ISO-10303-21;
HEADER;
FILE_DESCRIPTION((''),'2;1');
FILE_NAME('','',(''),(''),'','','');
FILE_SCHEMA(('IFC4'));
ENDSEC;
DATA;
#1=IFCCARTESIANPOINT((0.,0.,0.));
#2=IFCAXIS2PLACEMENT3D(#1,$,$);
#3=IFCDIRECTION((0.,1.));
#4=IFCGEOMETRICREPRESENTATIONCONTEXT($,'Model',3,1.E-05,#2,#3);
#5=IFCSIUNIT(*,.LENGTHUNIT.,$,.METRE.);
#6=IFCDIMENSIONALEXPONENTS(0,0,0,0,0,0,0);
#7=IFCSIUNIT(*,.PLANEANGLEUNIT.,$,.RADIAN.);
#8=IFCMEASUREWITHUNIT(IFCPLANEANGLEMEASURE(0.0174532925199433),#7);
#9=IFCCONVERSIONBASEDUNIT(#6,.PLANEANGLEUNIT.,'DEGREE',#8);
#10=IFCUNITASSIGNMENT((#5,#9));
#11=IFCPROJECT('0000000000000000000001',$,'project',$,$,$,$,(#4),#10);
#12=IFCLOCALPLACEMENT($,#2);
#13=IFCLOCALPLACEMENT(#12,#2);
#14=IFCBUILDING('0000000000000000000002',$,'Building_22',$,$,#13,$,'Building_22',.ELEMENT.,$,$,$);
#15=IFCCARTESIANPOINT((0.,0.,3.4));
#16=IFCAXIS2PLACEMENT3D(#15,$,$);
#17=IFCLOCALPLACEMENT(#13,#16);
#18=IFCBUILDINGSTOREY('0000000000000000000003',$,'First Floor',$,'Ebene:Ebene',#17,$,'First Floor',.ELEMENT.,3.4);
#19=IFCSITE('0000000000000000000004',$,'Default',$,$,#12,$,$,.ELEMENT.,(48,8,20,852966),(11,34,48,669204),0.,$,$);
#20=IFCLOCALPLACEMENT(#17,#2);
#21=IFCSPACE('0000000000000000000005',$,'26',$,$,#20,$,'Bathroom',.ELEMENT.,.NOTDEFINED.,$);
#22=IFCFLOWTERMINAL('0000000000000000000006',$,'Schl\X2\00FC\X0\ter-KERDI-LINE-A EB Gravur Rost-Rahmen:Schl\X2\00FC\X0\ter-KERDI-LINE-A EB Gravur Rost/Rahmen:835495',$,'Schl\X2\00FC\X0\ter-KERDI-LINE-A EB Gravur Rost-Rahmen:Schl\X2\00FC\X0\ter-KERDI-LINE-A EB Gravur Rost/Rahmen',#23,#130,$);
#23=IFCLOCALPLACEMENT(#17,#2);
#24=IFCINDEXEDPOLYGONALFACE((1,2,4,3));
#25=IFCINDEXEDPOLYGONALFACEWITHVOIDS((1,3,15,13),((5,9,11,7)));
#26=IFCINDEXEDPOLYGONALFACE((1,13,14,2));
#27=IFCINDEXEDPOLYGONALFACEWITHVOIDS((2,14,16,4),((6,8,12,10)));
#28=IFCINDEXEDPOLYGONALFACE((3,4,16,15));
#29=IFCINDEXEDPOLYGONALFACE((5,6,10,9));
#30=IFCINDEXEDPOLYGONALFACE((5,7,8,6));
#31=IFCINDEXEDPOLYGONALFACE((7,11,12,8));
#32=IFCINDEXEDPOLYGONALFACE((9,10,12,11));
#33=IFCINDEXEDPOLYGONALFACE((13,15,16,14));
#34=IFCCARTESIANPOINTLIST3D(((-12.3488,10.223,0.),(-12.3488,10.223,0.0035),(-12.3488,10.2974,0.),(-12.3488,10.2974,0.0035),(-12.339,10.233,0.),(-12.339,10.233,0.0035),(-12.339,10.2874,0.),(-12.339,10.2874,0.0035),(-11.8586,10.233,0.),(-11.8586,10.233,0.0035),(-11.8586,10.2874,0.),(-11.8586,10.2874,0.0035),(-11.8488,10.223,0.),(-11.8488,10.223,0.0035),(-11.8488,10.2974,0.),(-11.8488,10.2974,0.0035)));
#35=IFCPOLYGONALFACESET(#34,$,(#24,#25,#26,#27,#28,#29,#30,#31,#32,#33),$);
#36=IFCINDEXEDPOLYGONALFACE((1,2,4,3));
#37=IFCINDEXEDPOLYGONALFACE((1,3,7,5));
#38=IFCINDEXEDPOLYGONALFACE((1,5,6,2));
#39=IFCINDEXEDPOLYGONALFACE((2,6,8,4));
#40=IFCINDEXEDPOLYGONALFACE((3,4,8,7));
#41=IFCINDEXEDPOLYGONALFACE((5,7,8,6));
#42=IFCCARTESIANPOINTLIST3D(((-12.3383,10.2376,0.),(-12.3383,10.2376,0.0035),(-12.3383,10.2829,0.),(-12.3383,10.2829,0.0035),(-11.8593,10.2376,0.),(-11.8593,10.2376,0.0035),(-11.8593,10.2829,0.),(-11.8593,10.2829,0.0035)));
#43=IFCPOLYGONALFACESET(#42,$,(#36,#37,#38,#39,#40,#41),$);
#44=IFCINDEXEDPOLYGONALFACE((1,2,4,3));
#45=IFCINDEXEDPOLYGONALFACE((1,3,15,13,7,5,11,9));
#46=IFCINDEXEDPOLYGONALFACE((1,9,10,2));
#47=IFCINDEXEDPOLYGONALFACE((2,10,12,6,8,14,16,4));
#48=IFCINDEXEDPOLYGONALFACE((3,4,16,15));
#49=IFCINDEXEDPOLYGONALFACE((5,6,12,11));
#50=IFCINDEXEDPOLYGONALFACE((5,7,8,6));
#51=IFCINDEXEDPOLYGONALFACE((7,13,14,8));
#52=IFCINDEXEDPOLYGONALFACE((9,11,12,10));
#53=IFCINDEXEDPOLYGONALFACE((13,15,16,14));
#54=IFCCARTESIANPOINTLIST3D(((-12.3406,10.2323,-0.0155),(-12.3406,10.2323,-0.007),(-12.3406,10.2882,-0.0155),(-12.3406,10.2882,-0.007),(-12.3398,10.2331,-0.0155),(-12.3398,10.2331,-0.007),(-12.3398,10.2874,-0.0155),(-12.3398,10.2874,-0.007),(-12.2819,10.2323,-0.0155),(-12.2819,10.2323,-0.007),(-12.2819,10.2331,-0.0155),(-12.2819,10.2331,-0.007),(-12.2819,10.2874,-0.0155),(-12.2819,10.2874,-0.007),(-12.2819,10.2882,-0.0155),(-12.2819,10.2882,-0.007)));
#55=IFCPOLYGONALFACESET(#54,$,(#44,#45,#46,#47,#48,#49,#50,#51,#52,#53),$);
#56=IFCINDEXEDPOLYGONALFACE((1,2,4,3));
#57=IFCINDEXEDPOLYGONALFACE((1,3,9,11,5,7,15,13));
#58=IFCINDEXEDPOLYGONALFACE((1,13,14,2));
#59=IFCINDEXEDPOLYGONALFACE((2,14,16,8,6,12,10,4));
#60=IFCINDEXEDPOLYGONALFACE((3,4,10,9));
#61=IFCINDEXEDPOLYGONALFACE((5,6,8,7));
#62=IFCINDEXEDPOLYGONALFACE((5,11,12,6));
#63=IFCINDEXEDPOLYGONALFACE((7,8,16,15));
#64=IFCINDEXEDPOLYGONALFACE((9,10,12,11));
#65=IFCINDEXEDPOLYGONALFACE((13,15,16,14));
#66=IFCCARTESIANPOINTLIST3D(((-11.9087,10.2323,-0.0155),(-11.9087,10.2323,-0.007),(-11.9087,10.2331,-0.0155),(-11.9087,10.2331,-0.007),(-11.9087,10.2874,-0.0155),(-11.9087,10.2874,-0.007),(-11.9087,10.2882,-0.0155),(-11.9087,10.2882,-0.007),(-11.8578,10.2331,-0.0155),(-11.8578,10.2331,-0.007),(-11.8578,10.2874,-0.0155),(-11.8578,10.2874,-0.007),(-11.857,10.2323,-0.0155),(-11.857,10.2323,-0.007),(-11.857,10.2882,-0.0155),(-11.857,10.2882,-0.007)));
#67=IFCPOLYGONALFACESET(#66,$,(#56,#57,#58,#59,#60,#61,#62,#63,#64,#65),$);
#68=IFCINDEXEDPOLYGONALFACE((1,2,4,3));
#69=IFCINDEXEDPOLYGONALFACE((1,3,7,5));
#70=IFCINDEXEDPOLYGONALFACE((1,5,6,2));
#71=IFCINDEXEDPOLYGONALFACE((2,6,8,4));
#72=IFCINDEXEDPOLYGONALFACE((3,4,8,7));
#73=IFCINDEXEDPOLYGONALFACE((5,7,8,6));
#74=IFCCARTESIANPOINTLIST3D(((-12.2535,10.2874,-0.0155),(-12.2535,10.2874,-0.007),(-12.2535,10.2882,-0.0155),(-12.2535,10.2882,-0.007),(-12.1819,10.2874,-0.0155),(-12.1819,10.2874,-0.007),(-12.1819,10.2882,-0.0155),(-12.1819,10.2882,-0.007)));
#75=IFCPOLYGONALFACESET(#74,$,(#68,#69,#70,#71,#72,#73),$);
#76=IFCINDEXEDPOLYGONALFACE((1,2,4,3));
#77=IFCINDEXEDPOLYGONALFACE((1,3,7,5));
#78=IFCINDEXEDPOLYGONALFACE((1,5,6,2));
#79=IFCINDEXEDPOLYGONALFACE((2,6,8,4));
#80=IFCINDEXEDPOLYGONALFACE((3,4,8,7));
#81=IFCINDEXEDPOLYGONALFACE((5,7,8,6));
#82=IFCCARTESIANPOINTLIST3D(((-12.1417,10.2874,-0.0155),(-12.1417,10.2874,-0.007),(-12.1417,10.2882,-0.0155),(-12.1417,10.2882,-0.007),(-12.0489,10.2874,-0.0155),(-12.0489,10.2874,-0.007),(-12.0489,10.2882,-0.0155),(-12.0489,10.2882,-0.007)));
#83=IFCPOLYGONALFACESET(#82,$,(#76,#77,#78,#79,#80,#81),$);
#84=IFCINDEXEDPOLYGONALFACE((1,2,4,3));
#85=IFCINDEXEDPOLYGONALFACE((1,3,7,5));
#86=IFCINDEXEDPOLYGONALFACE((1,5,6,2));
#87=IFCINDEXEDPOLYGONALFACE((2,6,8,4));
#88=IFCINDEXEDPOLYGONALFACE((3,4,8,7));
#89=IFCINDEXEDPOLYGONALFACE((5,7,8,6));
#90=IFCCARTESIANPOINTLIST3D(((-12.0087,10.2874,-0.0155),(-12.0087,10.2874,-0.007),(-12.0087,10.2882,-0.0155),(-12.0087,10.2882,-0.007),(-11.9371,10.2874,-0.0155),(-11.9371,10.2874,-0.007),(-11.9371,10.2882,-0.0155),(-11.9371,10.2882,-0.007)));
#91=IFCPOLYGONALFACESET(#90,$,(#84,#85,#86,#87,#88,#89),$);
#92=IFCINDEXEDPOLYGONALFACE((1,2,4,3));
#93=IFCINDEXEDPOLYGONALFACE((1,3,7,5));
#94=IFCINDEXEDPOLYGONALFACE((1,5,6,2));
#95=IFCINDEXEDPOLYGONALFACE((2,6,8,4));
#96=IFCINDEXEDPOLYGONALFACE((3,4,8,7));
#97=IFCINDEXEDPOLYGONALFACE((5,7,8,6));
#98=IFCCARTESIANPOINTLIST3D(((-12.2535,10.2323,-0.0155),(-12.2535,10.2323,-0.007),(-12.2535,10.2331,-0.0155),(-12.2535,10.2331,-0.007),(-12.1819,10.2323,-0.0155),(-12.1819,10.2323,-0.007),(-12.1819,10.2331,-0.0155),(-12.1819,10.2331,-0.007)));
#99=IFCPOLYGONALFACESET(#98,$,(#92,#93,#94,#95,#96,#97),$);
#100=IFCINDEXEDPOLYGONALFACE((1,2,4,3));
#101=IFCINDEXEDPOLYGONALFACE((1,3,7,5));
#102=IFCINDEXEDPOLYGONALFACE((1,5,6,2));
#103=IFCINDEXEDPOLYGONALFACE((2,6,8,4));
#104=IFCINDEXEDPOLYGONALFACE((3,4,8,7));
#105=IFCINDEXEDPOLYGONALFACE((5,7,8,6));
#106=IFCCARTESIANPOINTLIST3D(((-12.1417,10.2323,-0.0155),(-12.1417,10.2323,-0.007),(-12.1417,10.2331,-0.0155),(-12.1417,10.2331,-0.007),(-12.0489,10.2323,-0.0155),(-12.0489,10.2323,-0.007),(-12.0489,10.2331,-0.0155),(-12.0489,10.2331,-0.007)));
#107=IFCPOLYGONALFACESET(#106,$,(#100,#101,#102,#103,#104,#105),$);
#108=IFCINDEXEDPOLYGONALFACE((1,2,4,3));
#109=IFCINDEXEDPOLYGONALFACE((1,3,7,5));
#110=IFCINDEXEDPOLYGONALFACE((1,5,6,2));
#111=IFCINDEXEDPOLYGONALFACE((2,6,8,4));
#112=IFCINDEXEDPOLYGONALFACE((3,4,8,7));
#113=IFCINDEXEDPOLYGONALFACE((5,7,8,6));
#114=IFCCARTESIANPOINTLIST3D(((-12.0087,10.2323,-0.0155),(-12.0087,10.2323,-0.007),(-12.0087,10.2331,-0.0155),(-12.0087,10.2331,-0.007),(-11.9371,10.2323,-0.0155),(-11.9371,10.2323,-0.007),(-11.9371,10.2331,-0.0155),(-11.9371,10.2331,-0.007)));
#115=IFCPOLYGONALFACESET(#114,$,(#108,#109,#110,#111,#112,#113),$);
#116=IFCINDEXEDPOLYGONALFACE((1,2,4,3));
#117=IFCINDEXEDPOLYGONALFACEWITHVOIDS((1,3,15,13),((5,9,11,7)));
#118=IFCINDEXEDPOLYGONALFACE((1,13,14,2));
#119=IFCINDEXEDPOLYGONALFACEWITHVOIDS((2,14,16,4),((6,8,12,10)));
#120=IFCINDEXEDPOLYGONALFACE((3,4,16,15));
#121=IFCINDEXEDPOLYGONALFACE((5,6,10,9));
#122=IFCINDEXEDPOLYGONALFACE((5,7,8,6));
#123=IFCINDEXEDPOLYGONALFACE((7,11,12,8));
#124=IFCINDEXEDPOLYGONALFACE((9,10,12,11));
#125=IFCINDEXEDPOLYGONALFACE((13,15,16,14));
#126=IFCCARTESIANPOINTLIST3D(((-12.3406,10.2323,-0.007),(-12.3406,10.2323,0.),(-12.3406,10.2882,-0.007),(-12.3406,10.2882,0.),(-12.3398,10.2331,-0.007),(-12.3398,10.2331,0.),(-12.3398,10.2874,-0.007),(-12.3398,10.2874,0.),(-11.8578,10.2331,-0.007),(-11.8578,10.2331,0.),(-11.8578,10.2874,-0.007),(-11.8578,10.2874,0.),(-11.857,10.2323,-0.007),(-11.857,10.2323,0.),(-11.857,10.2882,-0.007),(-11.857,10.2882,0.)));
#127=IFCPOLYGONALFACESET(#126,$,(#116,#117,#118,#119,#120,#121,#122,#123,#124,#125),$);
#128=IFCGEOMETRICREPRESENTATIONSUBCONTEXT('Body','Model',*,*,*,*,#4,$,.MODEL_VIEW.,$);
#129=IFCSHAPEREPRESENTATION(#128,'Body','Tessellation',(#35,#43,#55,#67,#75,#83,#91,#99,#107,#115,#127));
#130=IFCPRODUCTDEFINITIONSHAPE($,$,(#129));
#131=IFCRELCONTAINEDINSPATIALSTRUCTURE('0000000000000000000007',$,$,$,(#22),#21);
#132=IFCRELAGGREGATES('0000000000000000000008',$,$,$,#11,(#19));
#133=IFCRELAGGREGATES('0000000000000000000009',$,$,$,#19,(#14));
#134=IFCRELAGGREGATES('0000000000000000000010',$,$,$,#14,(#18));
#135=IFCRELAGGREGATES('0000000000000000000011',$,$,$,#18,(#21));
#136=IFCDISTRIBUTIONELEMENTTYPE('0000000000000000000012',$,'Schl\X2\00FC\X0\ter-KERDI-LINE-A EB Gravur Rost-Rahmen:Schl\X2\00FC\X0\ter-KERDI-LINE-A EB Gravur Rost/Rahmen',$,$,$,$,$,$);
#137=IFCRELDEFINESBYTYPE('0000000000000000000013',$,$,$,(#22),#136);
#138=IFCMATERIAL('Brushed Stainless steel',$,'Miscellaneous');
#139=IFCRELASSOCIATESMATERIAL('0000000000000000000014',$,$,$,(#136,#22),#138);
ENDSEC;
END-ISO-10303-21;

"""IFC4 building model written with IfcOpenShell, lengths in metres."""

from ifc_helpers import new_model, entity, si_unit, converted_unit, direction, frame, origin, place, context, subcontext, project, spatial, indexed_curve, outline, extrude, source, transform, mapped, material, type_object, type_shapes, element, save


model = new_model("IFC4")

# Units and contexts
model_context = context("Model", 3, precision=1e-05, world=origin(), true_north=direction((0.0, 1.0)))
body_context = subcontext(model_context, "Body", "Model", "MODEL_VIEW")
ifc_project = project(units=[si_unit("LENGTHUNIT", "METRE"), converted_unit("PLANEANGLEUNIT", "DEGREE", entity("IfcPlaneAngleMeasure", 0.0174532925199433), si_unit("PLANEANGLEUNIT", "RADIAN"), dimensions=[0, 0, 0, 0, 0, 0, 0])], contexts=[model_context])

# Site, building, storey
site_placement = place(None, origin())
site = spatial("IfcSite", under=ifc_project, at=site_placement, Name="Default", CompositionType="ELEMENT", RefLatitude=(48, 8, 20, 852966), RefLongitude=(11, 34, 48, 669204), RefElevation=0.0)
building_placement = place(site_placement, origin())
building = spatial("IfcBuilding", under=site, at=building_placement, Name="Building_22", LongName="Building_22", CompositionType="ELEMENT")
storey_placement = place(building_placement, frame((0.0, 0.0, 3.4)))
storey = spatial("IfcBuildingStorey", under=building, at=storey_placement, Name="First Floor", ObjectType="Ebene:Ebene", LongName="First Floor", CompositionType="ELEMENT", Elevation=3.4)

# Shared definitions
space_1_placement = place(storey_placement, origin())
space_1 = spatial("IfcSpace", under=storey, at=space_1_placement, Name="26", LongName="Bathroom", CompositionType="ELEMENT", PredefinedType="NOTDEFINED")

# Flow terminal
ifc_material_1 = material(Name="Brushed Stainless steel", Category="Miscellaneous")
distribution_element_type_1 = type_object("IfcDistributionElementType", Name="Schlüter-KERDI-LINE-A EB Gravur Rost-Rahmen:Schlüter-KERDI-LINE-A EB Gravur Rost/Rahmen", material=ifc_material_1)
shared_shape_1 = source(origin(), body_context, "Body", "SweptSolid", [
    extrude(outline(indexed_curve([(-0.25, -0.0372), (0.25, -0.0372), (0.25, 0.0372), (-0.25, 0.0372), (-0.25, -0.0372)], self_intersect=False), holes=[indexed_curve([(0.2402, 0.0272), (0.2402, -0.0272), (-0.2402, -0.0272), (-0.2402, 0.0272), (0.2402, 0.0272)], self_intersect=False)]), frame((0.0, 0.0, 0.0), z_axis=(0.0, 0.0, 1.0), x_axis=(-1.0, 0.0, 0.0)), (0.0, 0.0, 1.0), 0.0035),
    extrude(outline(indexed_curve([(-0.2395, -0.0227), (0.2395, -0.0227), (0.2395, 0.0227), (-0.2395, 0.0227), (-0.2395, -0.0227)], self_intersect=False)), frame((0.0, 0.0, 0.0), z_axis=(0.0, 0.0, 1.0), x_axis=(-1.0, 0.0, 0.0)), (0.0, 0.0, 1.0), 0.0035),
    extrude(outline(indexed_curve([(-0.0291, -0.028), (0.0295, -0.028), (0.0295, 0.028), (-0.0291, 0.028), (-0.0291, 0.0272), (0.0287, 0.0272), (0.0287, -0.0272), (-0.0291, -0.0272), (-0.0291, -0.028)], self_intersect=False)), frame((-0.2123, 0.0, -0.0155), z_axis=(0.0, 0.0, 1.0), x_axis=(-1.0, 0.0, 0.0)), (0.0, 0.0, 1.0), 0.0085),
    extrude(outline(indexed_curve([(-0.0272, -0.0252), (-0.0272, 0.0256), (-0.028, 0.0256), (-0.028, -0.026), (0.028, -0.026), (0.028, 0.0256), (0.0272, 0.0256), (0.0272, -0.0252), (-0.0272, -0.0252)], self_intersect=False)), frame((0.2158, 0.0, -0.0155), z_axis=(0.0, 0.0, -1.0), x_axis=(0.0, -1.0, 0.0)), (0.0, 0.0, -1.0), 0.0085),
    extrude(outline(indexed_curve([(-0.0358, -0.0004), (0.0358, -0.0004), (0.0358, 0.0004), (-0.0358, 0.0004), (-0.0358, -0.0004)], self_intersect=False)), frame((-0.1189, 0.0276, -0.0155)), (0.0, 0.0, 1.0), 0.0085),
    extrude(outline(indexed_curve([(-0.0464, -0.0004), (0.0464, -0.0004), (0.0464, 0.0004), (-0.0464, 0.0004), (-0.0464, -0.0004)], self_intersect=False)), frame((0.0035, 0.0276, -0.0155)), (0.0, 0.0, 1.0), 0.0085),
    extrude(outline(indexed_curve([(-0.0358, -0.0004), (0.0358, -0.0004), (0.0358, 0.0004), (-0.0358, 0.0004), (-0.0358, -0.0004)], self_intersect=False)), frame((0.1259, 0.0276, -0.0155)), (0.0, 0.0, 1.0), 0.0085),
    extrude(outline(indexed_curve([(-0.0004, -0.0358), (0.0004, -0.0358), (0.0004, 0.0358), (-0.0004, 0.0358), (-0.0004, -0.0358)], self_intersect=False)), frame((-0.1189, -0.0276, -0.0155), z_axis=(0.0, 0.0, 1.0), x_axis=(0.0, -1.0, 0.0)), (0.0, 0.0, 1.0), 0.0085),
    extrude(outline(indexed_curve([(-0.0004, -0.0464), (0.0004, -0.0464), (0.0004, 0.0464), (-0.0004, 0.0464), (-0.0004, -0.0464)], self_intersect=False)), frame((0.0035, -0.0276, -0.0155), z_axis=(0.0, 0.0, 1.0), x_axis=(0.0, -1.0, 0.0)), (0.0, 0.0, 1.0), 0.0085),
    extrude(outline(indexed_curve([(-0.0004, -0.0358), (0.0004, -0.0358), (0.0004, 0.0358), (-0.0004, 0.0358), (-0.0004, -0.0358)], self_intersect=False)), frame((0.1259, -0.0276, -0.0155), z_axis=(0.0, 0.0, 1.0), x_axis=(0.0, -1.0, 0.0)), (0.0, 0.0, 1.0), 0.0085),
    extrude(outline(indexed_curve([(-0.2418, -0.028), (0.2418, -0.028), (0.2418, 0.028), (-0.2418, 0.028), (-0.2418, -0.028)], self_intersect=False), holes=[indexed_curve([(0.241, -0.0272), (-0.241, -0.0272), (-0.241, 0.0272), (0.241, 0.0272), (0.241, -0.0272)], self_intersect=False)]), frame((0.0, 0.0, -0.007), z_axis=(0.0, 0.0, 1.0), x_axis=(-1.0, 0.0, 0.0)), (0.0, 0.0, 1.0), 0.007),
])
type_shapes(distribution_element_type_1, [shared_shape_1])
flow_terminal_1_placement = place(space_1_placement, frame((-12.0988, 10.2602, 0.0)))
element("IfcFlowTerminal", 1, at=flow_terminal_1_placement, inside=space_1, type_object=distribution_element_type_1, material=ifc_material_1, Name="Schlüter-KERDI-LINE-A EB Gravur Rost-Rahmen:Schlüter-KERDI-LINE-A EB Gravur Rost/Rahmen:835495", ObjectType="Schlüter-KERDI-LINE-A EB Gravur Rost-Rahmen:Schlüter-KERDI-LINE-A EB Gravur Rost/Rahmen", context=body_context, shape_type="MappedRepresentation", body=[
    mapped(shared_shape_1, transform((0.0, 0.0, 0.0), scale=1.0)),
])

save(model, "model.ifc")
